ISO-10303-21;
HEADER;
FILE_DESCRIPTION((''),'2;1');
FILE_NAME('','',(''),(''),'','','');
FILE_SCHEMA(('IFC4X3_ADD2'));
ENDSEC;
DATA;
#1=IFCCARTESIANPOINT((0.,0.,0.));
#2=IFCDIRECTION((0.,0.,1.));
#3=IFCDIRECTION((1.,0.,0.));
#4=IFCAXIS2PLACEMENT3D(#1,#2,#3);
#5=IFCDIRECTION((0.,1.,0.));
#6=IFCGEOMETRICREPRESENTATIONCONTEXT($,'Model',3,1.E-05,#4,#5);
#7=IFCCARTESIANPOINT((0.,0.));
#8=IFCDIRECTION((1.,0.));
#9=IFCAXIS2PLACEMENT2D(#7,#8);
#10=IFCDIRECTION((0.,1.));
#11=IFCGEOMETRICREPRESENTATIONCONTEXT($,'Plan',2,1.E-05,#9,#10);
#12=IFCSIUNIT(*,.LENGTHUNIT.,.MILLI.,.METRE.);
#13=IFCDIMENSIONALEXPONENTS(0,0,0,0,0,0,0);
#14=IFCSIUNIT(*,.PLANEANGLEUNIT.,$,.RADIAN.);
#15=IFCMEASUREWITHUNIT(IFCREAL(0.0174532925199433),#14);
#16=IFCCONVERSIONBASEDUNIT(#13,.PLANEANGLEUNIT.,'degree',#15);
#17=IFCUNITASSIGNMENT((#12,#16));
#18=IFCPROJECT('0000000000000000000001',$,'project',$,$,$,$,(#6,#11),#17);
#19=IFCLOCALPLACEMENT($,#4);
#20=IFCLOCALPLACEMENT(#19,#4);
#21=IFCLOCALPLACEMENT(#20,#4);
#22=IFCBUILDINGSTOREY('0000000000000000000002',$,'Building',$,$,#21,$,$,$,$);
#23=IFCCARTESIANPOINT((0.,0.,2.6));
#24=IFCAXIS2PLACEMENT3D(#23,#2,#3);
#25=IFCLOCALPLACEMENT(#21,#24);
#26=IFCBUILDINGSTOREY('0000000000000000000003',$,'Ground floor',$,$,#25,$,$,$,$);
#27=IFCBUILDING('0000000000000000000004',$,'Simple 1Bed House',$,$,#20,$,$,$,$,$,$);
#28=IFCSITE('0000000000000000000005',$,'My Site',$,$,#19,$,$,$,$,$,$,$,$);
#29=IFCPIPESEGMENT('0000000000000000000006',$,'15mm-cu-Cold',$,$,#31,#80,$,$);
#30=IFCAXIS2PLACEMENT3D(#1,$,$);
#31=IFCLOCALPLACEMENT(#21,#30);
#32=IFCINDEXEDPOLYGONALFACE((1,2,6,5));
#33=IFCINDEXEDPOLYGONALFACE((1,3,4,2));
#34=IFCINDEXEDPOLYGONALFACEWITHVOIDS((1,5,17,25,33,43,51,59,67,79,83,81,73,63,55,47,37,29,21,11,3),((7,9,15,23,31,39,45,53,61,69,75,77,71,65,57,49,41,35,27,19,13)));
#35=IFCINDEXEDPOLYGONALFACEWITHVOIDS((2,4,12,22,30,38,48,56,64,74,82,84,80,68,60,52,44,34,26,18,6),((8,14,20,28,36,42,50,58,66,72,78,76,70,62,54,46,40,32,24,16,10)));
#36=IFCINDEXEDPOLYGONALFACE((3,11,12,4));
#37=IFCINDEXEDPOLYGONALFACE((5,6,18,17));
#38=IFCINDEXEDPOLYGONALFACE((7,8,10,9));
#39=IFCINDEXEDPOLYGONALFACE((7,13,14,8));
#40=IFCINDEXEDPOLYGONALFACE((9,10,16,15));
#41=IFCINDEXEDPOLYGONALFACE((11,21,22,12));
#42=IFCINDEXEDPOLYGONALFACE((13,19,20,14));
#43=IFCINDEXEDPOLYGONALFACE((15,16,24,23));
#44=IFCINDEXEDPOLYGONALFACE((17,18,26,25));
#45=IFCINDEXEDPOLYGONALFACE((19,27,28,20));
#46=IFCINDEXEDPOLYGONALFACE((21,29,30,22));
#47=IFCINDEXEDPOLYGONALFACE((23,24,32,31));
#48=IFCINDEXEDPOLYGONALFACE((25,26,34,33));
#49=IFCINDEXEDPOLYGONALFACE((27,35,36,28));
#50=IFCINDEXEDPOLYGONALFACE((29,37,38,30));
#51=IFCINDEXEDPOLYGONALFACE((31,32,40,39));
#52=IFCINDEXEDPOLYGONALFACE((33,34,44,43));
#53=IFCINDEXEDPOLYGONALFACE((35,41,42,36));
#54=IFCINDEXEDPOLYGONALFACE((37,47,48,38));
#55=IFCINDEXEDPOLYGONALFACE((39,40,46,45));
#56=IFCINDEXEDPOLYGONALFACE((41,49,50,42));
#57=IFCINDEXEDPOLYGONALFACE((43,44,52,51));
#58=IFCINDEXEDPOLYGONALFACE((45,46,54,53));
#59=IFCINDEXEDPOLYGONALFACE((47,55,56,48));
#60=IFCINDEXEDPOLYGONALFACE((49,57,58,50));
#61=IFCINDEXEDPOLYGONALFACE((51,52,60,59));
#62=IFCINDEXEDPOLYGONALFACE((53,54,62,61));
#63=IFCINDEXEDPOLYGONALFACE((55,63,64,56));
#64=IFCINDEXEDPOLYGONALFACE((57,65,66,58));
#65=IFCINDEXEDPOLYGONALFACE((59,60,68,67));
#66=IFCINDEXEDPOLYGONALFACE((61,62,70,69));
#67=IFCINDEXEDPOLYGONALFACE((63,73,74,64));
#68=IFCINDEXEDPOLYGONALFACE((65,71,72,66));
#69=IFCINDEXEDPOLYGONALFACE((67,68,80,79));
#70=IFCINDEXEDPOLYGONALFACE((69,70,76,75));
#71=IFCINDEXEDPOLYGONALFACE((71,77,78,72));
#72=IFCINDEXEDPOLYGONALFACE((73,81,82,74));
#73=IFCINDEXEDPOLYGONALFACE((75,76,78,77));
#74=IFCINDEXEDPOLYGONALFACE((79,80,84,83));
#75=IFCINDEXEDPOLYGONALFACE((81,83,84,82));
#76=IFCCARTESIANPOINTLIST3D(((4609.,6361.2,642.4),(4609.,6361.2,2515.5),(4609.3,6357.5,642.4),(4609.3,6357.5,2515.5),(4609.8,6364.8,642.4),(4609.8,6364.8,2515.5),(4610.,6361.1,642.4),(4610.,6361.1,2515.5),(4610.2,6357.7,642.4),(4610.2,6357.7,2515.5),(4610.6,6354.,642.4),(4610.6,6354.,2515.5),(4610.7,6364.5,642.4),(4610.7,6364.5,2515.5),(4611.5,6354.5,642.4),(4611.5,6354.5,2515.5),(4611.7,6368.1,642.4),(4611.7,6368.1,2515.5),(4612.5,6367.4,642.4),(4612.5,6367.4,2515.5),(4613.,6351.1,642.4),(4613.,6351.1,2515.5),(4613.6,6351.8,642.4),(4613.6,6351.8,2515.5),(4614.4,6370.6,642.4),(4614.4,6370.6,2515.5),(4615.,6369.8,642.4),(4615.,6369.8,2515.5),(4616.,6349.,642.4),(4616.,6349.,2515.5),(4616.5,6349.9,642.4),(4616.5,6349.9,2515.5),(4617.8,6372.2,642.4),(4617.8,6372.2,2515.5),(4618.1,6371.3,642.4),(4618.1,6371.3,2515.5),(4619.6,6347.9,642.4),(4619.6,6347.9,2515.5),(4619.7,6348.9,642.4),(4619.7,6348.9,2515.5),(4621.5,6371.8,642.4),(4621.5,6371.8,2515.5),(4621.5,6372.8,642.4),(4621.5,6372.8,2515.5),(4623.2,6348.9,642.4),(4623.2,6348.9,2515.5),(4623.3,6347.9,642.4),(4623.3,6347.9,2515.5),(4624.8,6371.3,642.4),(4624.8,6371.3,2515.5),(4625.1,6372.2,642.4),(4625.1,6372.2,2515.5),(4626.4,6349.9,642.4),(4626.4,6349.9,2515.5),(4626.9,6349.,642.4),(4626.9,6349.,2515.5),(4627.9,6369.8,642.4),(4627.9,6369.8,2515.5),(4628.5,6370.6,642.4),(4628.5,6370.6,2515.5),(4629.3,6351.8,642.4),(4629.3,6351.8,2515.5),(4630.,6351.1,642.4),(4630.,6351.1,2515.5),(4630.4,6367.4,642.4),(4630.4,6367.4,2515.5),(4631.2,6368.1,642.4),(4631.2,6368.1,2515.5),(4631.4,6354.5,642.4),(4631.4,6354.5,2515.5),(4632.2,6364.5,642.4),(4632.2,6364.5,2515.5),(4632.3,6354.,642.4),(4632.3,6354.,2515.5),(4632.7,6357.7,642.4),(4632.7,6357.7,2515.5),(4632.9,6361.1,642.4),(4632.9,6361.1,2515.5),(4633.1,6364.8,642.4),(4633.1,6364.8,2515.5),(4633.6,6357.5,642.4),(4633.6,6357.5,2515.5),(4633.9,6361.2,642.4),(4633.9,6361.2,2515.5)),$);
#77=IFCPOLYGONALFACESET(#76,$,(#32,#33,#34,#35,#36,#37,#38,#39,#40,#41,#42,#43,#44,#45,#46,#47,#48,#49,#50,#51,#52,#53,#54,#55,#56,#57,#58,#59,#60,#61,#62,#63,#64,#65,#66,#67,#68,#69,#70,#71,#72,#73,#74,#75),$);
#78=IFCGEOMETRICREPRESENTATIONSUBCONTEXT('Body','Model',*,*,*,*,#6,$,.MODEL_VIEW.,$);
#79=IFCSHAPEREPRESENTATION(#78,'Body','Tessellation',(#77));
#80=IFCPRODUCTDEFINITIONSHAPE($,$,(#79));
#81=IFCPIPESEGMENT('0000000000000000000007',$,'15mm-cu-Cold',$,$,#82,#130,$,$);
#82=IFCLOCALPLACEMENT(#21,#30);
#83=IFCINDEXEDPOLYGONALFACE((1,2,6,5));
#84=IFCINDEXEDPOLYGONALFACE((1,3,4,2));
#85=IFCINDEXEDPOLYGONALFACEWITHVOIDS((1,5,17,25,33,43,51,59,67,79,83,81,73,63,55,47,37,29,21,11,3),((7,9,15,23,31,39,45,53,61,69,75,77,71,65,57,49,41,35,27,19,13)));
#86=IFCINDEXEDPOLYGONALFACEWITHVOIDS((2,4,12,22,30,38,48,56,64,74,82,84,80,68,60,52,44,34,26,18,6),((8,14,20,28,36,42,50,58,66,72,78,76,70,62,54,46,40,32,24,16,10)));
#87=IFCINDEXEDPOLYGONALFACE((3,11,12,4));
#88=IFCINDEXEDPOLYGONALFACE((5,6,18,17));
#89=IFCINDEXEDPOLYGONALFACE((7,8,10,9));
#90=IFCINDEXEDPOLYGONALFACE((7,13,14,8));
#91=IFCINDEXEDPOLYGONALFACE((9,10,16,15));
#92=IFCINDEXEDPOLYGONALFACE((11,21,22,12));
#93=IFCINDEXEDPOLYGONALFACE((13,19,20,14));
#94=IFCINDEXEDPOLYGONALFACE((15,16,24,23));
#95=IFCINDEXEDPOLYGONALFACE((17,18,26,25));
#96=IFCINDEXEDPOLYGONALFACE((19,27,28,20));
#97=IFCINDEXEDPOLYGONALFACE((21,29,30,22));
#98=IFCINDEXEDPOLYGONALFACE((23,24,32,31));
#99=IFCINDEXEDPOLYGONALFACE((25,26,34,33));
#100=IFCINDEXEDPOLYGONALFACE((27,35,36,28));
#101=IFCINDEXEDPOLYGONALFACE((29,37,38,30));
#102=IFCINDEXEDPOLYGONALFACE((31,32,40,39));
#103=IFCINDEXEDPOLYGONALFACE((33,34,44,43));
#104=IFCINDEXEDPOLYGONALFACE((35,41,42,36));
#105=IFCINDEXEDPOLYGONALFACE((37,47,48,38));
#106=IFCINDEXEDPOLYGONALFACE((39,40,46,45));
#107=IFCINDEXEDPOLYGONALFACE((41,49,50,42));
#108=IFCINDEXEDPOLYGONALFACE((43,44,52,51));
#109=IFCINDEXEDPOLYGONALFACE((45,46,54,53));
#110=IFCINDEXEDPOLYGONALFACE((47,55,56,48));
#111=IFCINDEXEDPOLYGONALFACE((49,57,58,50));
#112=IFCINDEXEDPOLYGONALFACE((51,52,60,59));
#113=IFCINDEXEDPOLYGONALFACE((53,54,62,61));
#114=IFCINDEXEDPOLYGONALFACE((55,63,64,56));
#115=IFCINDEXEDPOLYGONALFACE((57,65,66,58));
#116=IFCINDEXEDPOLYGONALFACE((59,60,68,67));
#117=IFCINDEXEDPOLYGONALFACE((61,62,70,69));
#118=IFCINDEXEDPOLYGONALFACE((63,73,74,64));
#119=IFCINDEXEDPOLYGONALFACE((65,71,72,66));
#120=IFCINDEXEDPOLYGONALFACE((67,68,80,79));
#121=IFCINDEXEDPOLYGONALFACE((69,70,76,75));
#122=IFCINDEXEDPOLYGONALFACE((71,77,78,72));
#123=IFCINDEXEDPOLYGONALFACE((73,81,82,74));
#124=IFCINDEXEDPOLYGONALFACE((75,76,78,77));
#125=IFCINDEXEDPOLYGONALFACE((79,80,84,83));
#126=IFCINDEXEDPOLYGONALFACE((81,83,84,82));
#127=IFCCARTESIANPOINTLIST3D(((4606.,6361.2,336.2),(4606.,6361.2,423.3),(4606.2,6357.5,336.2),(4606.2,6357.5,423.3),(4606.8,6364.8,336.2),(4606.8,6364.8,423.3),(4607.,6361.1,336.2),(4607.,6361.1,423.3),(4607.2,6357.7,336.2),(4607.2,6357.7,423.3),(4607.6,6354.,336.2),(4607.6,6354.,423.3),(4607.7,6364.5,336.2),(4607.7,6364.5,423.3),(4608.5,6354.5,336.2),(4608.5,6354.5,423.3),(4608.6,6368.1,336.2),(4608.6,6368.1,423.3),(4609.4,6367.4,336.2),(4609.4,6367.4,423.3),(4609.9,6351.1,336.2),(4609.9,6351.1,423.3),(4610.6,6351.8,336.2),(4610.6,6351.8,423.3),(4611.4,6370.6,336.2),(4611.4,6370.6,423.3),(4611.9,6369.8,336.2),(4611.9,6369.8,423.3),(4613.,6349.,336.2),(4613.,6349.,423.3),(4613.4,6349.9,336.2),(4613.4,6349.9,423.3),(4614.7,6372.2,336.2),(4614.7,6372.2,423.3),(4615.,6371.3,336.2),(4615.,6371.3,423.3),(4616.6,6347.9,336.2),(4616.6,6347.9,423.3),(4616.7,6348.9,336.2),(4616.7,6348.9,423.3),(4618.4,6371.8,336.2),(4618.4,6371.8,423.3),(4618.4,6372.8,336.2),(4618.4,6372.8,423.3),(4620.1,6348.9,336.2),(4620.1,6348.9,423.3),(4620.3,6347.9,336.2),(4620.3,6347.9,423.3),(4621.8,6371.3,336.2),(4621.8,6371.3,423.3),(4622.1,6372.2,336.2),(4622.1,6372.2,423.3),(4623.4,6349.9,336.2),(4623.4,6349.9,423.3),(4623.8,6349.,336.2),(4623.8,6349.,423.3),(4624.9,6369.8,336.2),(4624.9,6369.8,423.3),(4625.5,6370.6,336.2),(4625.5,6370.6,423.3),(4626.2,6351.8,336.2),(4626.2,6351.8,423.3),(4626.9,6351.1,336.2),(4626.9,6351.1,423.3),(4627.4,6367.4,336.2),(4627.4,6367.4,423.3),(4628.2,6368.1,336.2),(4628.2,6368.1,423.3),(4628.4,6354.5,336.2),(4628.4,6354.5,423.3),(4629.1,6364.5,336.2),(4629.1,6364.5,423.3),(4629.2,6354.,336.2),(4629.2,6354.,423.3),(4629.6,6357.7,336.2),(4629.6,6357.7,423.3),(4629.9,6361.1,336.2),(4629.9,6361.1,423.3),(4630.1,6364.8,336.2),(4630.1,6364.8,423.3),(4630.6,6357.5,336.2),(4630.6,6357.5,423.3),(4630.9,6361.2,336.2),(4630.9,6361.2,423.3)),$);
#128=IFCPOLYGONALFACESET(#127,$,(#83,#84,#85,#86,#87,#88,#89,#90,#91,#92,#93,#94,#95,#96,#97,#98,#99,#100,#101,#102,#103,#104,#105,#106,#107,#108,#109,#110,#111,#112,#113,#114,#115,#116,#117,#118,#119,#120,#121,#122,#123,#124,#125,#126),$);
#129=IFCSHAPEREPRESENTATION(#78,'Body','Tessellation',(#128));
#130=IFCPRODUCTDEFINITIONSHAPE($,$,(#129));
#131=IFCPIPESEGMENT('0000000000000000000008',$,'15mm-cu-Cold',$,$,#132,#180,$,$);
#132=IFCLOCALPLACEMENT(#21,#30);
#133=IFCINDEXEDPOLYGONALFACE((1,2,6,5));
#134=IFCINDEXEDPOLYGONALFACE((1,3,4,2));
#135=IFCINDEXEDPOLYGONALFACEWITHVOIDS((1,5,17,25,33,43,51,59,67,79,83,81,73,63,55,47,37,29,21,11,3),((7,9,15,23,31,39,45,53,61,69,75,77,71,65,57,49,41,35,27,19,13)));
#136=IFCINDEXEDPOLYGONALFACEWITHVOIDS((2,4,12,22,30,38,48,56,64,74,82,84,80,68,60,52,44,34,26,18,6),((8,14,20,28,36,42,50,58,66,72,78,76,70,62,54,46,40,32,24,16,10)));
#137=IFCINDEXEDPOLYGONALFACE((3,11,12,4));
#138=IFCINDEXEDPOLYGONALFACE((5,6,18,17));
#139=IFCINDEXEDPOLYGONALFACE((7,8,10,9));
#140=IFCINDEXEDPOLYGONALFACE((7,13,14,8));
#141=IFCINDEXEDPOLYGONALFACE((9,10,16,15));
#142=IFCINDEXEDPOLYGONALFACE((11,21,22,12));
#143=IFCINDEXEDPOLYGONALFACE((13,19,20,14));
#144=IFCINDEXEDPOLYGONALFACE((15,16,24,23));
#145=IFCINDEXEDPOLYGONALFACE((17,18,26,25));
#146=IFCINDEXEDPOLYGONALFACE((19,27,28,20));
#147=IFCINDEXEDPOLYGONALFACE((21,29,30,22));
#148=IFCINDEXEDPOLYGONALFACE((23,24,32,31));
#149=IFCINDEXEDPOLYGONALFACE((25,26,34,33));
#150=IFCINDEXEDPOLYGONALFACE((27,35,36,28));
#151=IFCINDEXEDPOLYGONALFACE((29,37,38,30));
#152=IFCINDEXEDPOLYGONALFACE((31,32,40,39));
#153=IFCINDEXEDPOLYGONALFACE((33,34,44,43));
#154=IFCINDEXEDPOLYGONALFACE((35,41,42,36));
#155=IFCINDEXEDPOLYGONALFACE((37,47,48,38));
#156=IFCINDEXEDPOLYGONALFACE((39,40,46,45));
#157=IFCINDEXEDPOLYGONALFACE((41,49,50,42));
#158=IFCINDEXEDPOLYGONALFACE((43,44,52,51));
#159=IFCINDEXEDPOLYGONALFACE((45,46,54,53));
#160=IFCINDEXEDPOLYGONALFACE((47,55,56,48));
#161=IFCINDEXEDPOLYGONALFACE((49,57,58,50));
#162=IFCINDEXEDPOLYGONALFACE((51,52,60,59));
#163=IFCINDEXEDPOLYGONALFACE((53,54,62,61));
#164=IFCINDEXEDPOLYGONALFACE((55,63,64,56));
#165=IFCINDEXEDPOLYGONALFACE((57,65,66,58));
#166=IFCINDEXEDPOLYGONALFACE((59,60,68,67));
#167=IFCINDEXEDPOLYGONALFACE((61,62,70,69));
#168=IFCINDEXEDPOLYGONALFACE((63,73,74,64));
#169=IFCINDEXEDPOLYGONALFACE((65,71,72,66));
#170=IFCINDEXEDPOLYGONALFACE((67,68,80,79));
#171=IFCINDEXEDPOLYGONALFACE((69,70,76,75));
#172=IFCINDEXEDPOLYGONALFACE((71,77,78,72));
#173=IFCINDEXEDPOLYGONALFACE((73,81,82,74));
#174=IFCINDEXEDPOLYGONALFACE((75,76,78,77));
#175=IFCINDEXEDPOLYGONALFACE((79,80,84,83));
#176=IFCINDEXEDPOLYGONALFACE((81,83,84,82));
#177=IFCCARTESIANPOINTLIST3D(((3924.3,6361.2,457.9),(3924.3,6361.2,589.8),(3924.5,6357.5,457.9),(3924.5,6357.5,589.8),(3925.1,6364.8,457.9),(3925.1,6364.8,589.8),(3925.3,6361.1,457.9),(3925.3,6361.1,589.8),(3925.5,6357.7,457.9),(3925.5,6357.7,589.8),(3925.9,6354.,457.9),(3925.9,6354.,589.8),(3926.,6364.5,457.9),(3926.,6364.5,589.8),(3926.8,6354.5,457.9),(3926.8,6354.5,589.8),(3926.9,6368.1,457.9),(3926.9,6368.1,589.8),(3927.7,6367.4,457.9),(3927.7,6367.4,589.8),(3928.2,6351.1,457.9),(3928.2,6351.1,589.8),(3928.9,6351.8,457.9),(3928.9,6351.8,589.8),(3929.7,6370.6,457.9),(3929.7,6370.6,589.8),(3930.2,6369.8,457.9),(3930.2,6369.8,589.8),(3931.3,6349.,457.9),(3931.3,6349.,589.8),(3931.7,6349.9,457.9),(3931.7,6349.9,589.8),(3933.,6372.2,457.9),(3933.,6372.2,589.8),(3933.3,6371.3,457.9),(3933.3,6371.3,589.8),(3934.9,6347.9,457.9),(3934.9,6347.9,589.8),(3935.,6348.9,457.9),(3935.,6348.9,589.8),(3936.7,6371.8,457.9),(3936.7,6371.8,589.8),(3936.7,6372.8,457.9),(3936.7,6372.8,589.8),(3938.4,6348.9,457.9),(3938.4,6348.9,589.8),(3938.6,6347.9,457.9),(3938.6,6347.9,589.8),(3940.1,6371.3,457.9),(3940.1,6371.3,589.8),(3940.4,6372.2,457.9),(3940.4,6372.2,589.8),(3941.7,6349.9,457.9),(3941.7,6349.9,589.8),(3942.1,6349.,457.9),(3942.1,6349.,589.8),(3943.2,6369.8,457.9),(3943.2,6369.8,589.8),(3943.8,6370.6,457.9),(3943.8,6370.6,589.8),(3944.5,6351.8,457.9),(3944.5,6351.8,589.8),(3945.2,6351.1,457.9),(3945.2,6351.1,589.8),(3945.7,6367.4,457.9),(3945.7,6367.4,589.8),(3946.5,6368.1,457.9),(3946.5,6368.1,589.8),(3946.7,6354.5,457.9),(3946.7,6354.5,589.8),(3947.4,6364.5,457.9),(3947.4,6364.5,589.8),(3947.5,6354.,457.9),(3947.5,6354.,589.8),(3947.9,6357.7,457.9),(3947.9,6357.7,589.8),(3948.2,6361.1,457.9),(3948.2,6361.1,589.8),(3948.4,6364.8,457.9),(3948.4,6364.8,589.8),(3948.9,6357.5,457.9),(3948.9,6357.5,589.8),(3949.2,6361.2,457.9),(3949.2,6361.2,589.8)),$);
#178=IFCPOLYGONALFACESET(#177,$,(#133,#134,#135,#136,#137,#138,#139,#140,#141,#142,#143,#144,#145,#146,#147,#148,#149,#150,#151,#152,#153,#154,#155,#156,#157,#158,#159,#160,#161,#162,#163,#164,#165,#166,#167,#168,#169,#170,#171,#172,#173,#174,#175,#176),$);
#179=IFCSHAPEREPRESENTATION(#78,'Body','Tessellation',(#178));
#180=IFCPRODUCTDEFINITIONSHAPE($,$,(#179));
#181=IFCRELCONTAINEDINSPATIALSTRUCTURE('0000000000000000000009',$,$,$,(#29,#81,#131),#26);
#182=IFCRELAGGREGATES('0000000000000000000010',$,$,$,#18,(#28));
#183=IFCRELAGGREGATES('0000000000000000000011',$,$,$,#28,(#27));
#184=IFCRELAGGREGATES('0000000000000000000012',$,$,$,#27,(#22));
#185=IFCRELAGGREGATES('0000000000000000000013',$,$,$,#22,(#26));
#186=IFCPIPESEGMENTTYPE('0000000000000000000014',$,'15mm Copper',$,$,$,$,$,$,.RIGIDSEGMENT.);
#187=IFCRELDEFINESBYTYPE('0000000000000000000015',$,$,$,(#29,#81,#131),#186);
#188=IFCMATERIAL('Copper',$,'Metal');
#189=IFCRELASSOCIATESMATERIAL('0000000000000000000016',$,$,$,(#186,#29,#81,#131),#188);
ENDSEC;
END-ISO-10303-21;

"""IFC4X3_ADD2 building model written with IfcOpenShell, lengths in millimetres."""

from ifc_helpers import new_model, entity, si_unit, converted_unit, direction, frame, origin_with_axes, origin_2d_with_axis, place, context, subcontext, project, spatial, hollow_circle, extrude, material, material_profile, profile_set, profile_usage, type_object, element, save


model = new_model("IFC4X3_ADD2")

# Units and contexts
model_context = context("Model", 3, precision=1e-05, world=origin_with_axes(), true_north=direction((0.0, 1.0, 0.0)))
plan_context = context("Plan", 2, precision=1e-05, world=origin_2d_with_axis(), true_north=direction((0.0, 1.0)))
body_context_1 = subcontext(model_context, "Body", "Model", "MODEL_VIEW")
ifc_project = project(units=[si_unit("LENGTHUNIT", "METRE", prefix="MILLI"), converted_unit("PLANEANGLEUNIT", "degree", entity("IfcReal", 0.0174532925199433), si_unit("PLANEANGLEUNIT", "RADIAN"), dimensions=[0, 0, 0, 0, 0, 0, 0])], contexts=[model_context, plan_context])

# Site, building, storeys
site_placement = place(None, origin_with_axes())
site = spatial("IfcSite", under=ifc_project, at=site_placement, Name="My Site")
building_placement = place(site_placement, origin_with_axes())
building = spatial("IfcBuilding", under=site, at=building_placement, Name="Simple 1Bed House")
storey_1_placement = place(building_placement, origin_with_axes())
storey_1 = spatial("IfcBuildingStorey", under=building, at=storey_1_placement, Name="Building")
storey_2_placement = place(storey_1_placement, frame((0.0, 0.0, 2.6), z_axis=(0.0, 0.0, 1.0), x_axis=(1.0, 0.0, 0.0)))
storey_2 = spatial("IfcBuildingStorey", under=storey_1, at=storey_2_placement, Name="Ground floor")

# Pipe segments
ifc_material_1 = material(Name="Copper", Category="Metal")
ifc_material_profile = material_profile(ifc_material_1, hollow_circle(Radius=12.5, WallThickness=1.0))
ifc_profile_set = profile_set([ifc_material_profile])
pipe_segment_type = type_object("IfcPipeSegmentType", Name="15mm Copper", PredefinedType="RIGIDSEGMENT", material=ifc_profile_set)
ifc_profile_usage_1 = profile_usage(ifc_profile_set, cardinal=5)
pipe_segment_1_placement = place(storey_2_placement, frame((4621.5, 6360.3, 2512.9), z_axis=(0.0, 0.0, -1.0), x_axis=(0.0, 1.0, 0.0)))
element("IfcPipeSegment", 1, at=pipe_segment_1_placement, inside=storey_2, type_object=pipe_segment_type, material=ifc_profile_usage_1, Name="15mm-cu-Cold", context=body_context_1, shape_type="SweptSolid", body=[
    extrude(hollow_circle(Radius=12.5, WallThickness=1.0), origin_with_axes(), (0.0, 0.0, 1.0), 1873.1),
])
ifc_profile_usage_2 = profile_usage(ifc_profile_set, cardinal=5)
pipe_segment_2_placement = place(storey_2_placement, frame((4618.4, 6360.3, 420.7), z_axis=(0.0, 0.0, -1.0), x_axis=(0.0, 1.0, 0.0)))
element("IfcPipeSegment", 2, at=pipe_segment_2_placement, inside=storey_2, type_object=pipe_segment_type, material=ifc_profile_usage_2, Name="15mm-cu-Cold", context=body_context_1, shape_type="SweptSolid", body=[
    extrude(hollow_circle(Radius=12.5, WallThickness=1.0), origin_with_axes(), (0.0, 0.0, 1.0), 87.1),
])
ifc_profile_usage_3 = profile_usage(ifc_profile_set, cardinal=5)
pipe_segment_3_placement = place(storey_2_placement, frame((3936.7, 6360.3, 587.2), z_axis=(0.0, 0.0, -1.0), x_axis=(0.0, 1.0, 0.0)))
element("IfcPipeSegment", 3, at=pipe_segment_3_placement, inside=storey_2, type_object=pipe_segment_type, material=ifc_profile_usage_3, Name="15mm-cu-Cold", context=body_context_1, shape_type="SweptSolid", body=[
    extrude(hollow_circle(Radius=12.5, WallThickness=1.0), origin_with_axes(), (0.0, 0.0, 1.0), 131.9),
])

save(model, "model.ifc")
